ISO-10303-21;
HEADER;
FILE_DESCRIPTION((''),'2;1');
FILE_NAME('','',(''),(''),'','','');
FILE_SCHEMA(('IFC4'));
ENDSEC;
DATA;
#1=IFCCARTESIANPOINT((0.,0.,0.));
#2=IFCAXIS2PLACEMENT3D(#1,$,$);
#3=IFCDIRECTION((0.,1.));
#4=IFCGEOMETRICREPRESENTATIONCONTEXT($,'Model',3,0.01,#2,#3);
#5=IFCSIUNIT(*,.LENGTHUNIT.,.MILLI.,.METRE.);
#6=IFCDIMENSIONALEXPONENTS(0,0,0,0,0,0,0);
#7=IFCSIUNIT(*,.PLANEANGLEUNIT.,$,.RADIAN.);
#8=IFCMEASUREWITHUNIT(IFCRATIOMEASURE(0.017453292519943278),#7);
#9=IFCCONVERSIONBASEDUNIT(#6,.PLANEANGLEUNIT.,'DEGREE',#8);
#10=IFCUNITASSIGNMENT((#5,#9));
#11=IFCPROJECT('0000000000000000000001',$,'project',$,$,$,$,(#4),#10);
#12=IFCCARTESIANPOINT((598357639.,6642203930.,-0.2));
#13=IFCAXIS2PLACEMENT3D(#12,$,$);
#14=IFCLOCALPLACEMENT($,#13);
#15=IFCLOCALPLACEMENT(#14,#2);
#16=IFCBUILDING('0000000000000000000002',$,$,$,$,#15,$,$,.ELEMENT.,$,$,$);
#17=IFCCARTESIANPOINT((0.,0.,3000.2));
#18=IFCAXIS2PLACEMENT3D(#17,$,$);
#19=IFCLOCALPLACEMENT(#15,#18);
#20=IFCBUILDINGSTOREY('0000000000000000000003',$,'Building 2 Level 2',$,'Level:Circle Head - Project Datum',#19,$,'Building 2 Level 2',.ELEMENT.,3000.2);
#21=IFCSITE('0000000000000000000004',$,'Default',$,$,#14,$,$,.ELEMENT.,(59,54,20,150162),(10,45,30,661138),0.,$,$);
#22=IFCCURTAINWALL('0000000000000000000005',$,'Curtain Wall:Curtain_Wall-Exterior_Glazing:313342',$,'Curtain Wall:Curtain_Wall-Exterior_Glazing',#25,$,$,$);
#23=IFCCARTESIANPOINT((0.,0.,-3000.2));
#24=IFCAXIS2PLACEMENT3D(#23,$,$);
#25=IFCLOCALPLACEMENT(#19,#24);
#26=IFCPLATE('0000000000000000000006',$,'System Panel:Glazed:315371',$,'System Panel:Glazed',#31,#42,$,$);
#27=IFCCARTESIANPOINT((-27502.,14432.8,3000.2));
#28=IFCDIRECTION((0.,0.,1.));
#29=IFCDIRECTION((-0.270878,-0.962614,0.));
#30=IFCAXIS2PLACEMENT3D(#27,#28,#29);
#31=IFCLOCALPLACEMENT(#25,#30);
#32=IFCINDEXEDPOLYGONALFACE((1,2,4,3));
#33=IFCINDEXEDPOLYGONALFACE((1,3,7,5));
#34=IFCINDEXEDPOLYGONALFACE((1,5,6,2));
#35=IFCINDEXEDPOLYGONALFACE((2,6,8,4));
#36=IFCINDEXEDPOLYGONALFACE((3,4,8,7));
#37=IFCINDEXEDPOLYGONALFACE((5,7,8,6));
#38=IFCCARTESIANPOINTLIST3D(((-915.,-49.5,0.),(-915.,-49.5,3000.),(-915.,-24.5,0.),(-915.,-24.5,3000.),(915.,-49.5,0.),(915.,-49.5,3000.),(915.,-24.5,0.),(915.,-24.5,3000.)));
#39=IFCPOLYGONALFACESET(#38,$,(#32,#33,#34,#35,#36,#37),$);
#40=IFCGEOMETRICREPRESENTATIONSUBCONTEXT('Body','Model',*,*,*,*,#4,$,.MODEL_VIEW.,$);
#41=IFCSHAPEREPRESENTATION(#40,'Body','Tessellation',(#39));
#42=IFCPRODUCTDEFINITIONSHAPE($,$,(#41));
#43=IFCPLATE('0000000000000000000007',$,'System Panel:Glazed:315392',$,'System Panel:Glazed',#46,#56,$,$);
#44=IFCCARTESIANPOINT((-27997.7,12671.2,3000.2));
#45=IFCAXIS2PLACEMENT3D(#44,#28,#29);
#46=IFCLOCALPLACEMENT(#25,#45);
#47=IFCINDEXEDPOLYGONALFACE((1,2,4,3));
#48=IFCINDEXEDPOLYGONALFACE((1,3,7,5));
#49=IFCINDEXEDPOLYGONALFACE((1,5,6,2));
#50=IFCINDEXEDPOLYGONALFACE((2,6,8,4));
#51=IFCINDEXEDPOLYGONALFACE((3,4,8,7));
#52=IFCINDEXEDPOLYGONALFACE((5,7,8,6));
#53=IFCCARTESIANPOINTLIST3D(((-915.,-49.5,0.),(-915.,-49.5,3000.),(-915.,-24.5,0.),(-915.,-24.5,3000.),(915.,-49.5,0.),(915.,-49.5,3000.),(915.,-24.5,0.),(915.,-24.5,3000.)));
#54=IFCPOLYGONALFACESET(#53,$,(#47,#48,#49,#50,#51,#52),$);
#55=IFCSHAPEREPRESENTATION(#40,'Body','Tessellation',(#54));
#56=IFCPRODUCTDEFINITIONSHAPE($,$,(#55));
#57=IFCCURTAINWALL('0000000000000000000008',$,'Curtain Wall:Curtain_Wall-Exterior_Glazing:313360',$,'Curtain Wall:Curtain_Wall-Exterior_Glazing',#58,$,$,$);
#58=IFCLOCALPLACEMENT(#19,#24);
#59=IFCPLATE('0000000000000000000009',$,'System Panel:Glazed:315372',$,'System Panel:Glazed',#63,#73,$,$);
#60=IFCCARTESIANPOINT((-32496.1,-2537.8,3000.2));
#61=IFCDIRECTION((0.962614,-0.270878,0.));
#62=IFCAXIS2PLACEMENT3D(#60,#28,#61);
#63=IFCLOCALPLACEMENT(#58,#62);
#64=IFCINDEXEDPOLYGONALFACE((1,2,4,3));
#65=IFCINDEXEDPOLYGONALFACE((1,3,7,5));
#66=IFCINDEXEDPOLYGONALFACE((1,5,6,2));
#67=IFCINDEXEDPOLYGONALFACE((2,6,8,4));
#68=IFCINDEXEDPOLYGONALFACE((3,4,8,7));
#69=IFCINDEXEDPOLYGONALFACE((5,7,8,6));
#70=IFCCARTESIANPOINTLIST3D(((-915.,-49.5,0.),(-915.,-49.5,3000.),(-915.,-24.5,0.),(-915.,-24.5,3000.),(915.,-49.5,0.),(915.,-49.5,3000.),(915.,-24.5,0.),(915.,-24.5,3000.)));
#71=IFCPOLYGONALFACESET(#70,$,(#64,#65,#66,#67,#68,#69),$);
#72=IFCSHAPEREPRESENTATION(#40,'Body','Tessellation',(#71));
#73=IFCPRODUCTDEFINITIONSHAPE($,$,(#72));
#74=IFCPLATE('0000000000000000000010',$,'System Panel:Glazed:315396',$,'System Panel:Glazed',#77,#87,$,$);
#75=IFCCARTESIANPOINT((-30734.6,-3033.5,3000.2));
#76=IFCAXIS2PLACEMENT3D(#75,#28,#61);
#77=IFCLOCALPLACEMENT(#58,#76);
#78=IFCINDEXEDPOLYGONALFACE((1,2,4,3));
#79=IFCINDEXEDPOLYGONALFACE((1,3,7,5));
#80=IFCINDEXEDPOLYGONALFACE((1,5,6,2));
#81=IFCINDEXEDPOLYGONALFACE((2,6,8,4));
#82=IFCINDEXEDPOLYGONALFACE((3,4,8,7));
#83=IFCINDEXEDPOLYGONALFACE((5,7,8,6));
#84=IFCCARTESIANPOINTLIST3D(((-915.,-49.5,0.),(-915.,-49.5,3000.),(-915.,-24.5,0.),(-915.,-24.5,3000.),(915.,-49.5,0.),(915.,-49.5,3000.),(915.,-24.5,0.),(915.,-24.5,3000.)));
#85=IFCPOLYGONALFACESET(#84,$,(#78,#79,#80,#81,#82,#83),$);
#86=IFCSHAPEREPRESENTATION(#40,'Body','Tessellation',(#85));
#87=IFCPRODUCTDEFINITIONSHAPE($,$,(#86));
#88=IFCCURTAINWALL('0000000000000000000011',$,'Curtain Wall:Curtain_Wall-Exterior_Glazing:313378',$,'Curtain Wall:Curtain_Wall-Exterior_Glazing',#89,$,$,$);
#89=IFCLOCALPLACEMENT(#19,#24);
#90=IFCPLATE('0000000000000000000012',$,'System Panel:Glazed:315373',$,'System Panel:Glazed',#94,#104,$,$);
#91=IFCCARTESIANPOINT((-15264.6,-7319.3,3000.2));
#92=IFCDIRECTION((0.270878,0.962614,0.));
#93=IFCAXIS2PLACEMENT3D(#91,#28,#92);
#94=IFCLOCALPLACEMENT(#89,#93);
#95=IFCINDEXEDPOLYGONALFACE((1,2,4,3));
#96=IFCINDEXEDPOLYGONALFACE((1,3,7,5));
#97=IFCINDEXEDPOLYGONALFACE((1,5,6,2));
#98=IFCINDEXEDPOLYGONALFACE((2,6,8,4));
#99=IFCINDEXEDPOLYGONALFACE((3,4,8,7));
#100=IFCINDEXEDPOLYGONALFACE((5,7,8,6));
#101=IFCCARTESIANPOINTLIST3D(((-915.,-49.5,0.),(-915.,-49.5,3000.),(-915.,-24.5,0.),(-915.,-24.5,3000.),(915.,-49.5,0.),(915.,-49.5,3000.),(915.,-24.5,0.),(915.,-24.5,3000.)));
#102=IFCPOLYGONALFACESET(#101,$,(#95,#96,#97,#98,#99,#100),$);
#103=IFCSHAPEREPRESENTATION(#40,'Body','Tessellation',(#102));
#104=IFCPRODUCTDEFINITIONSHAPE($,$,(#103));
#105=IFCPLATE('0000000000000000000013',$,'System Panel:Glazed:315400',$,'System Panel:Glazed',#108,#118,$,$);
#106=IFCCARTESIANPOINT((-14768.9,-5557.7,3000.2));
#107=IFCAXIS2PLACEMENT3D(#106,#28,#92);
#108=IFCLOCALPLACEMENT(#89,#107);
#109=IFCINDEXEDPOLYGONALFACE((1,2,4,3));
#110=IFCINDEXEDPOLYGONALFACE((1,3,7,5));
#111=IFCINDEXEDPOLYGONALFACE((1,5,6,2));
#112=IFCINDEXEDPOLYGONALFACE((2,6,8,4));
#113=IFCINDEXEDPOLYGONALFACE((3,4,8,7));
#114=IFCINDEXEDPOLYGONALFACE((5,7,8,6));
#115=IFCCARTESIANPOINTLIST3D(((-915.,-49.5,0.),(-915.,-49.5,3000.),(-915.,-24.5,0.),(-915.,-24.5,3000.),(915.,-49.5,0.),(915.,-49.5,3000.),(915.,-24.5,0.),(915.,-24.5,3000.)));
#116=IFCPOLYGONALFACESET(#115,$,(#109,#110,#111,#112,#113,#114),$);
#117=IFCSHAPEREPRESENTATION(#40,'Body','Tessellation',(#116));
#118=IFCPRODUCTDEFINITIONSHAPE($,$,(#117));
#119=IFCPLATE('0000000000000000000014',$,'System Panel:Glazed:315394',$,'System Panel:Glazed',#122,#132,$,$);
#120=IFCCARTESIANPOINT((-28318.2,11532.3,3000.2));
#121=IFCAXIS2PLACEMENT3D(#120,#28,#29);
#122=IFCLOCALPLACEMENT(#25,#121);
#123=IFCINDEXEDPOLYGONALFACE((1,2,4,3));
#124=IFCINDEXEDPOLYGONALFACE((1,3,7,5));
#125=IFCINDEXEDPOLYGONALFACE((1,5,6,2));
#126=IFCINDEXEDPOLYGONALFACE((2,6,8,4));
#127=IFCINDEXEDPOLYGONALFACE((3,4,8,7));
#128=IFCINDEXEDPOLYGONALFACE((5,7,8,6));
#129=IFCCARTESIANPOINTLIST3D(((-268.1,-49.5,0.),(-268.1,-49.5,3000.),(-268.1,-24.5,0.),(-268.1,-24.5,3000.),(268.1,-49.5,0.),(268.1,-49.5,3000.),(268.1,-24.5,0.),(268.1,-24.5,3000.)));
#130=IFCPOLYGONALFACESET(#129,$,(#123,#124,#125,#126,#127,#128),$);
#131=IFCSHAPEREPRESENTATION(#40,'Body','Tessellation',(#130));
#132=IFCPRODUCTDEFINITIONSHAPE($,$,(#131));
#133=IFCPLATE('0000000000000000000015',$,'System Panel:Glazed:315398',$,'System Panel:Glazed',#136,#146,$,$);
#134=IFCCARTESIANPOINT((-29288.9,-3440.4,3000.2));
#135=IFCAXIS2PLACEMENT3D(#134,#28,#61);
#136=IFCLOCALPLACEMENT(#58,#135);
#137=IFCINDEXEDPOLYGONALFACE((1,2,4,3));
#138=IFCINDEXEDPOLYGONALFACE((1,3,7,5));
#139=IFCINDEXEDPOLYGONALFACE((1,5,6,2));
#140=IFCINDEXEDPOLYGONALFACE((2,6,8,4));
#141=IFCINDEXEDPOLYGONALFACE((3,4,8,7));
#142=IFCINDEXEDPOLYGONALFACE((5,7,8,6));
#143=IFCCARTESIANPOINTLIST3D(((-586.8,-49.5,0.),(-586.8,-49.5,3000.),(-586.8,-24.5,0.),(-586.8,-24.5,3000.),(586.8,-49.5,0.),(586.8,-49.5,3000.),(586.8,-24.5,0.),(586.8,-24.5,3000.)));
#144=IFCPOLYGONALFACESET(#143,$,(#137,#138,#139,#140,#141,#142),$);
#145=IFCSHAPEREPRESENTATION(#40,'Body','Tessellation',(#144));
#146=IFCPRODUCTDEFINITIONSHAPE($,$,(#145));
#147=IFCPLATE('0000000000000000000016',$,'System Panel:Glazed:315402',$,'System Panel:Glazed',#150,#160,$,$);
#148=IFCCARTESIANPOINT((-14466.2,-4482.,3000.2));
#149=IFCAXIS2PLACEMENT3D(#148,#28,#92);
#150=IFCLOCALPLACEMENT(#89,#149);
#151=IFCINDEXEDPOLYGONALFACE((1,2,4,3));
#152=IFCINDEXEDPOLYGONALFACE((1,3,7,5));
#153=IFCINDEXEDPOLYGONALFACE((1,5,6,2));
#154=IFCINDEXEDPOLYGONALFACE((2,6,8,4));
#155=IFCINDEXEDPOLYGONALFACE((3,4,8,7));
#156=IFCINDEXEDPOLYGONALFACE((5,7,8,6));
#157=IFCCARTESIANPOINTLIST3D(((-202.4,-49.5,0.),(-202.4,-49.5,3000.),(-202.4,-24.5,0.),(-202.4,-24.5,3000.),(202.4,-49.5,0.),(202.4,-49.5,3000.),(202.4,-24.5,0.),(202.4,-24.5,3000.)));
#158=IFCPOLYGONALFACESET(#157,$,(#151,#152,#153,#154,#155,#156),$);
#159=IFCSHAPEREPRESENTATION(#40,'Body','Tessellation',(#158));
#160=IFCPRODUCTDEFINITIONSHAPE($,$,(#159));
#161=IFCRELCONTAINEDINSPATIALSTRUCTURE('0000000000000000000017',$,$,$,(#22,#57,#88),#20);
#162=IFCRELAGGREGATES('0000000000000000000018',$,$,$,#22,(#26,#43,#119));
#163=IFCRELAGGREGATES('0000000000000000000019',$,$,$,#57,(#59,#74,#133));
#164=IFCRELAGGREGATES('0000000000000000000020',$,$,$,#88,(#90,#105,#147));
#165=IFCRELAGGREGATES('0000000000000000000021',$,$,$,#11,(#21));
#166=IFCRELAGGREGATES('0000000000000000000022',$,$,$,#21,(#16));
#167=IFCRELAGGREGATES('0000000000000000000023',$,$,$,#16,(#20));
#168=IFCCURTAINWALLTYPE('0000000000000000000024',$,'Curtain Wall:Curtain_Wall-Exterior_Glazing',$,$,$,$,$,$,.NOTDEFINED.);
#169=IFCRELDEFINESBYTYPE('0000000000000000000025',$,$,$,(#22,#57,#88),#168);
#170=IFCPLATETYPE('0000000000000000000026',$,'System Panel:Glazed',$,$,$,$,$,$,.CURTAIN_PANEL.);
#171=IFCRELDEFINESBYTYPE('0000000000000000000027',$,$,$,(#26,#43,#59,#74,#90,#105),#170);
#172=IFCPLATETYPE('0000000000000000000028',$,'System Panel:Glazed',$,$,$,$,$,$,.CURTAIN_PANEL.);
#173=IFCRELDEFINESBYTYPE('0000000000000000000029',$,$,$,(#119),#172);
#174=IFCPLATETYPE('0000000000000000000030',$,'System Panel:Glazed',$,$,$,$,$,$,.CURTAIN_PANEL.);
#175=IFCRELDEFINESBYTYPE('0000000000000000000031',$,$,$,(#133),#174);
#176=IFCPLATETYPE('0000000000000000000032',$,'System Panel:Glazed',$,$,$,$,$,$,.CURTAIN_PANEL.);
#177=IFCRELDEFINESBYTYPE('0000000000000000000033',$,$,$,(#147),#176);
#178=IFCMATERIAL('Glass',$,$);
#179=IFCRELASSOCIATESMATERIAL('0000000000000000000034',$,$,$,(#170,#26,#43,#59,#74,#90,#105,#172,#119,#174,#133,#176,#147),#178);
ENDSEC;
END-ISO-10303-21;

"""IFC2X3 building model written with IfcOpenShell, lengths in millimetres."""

from ifc_helpers import new_model, entity, si_unit, converted_unit, direction, frame, frame_2d, origin, place, context, subcontext, project, spatial, rectangle, extrude, source, transform, mapped, material, type_object, type_shapes, element, aggregate, save


model = new_model("IFC2X3")

# Units and contexts
model_context = context("Model", 3, precision=0.01, world=origin(), true_north=direction((0.0, 1.0)))
body_context = subcontext(model_context, "Body", "Model", "MODEL_VIEW")
ifc_project = project(units=[si_unit("LENGTHUNIT", "METRE", prefix="MILLI"), converted_unit("PLANEANGLEUNIT", "DEGREE", entity("IfcRatioMeasure", 0.017453292519943278), si_unit("PLANEANGLEUNIT", "RADIAN"), dimensions=[0, 0, 0, 0, 0, 0, 0])], contexts=[model_context])

# Site, building, storey
site_placement = place(None, frame((598357639.0, 6642203930.0, -0.2)))
site = spatial("IfcSite", under=ifc_project, at=site_placement, Name="Default", CompositionType="ELEMENT", RefLatitude=(59, 54, 20, 150162), RefLongitude=(10, 45, 30, 661138), RefElevation=0.0)
building_placement = place(site_placement, origin())
building = spatial("IfcBuilding", under=site, at=building_placement, CompositionType="ELEMENT")
storey_placement = place(building_placement, frame((0.0, 0.0, 3000.2)))
storey = spatial("IfcBuildingStorey", under=building, at=storey_placement, Name="Building 2 Level 2", ObjectType="Level:Circle Head - Project Datum", LongName="Building 2 Level 2", CompositionType="ELEMENT", Elevation=3000.2)

# Curtain walls, plates
curtain_wall_type = type_object("IfcCurtainWallType", Name="Curtain Wall:Curtain_Wall-Exterior_Glazing", PredefinedType="NOTDEFINED")
curtain_wall_1_placement = place(storey_placement, frame((0.0, 0.0, -3000.2)))
curtain_wall_1 = element("IfcCurtainWall", 1, at=curtain_wall_1_placement, inside=storey, type_object=curtain_wall_type, Name="Curtain Wall:Curtain_Wall-Exterior_Glazing:313342", ObjectType="Curtain Wall:Curtain_Wall-Exterior_Glazing")
ifc_material_1 = material(Name="Glass")
plate_type_1 = type_object("IfcPlateType", Name="System Panel:Glazed", PredefinedType="CURTAIN_PANEL", material=ifc_material_1)
shared_shape_1 = source(origin(), body_context, "Body", "SweptSolid", [
    extrude(rectangle(XDim=25.0, YDim=1830.0, at=frame_2d((0.0, 0.0), x_axis=(1.0, 0.0))), frame((0.0, -37.0, 0.0), z_axis=(0.0, 0.0, 1.0), x_axis=(0.0, 1.0, 0.0)), (0.0, 0.0, 1.0), 3000.0),
])
type_shapes(plate_type_1, [shared_shape_1])
plate_1_placement = place(curtain_wall_1_placement, frame((-27502.0, 14432.8, 3000.2), z_axis=(0.0, 0.0, 1.0), x_axis=(-0.270878, -0.962614, 0.0)))
plate_1 = element("IfcPlate", 2, at=plate_1_placement, type_object=plate_type_1, material=ifc_material_1, Name="System Panel:Glazed:315371", ObjectType="System Panel:Glazed", context=body_context, shape_type="MappedRepresentation", body=[
    mapped(shared_shape_1, transform((0.0, 0.0, 0.0), scale=1.0)),
])
plate_2_placement = place(curtain_wall_1_placement, frame((-27997.7, 12671.2, 3000.2), z_axis=(0.0, 0.0, 1.0), x_axis=(-0.270878, -0.962614, 0.0)))
plate_2 = element("IfcPlate", 3, at=plate_2_placement, type_object=plate_type_1, material=ifc_material_1, Name="System Panel:Glazed:315392", ObjectType="System Panel:Glazed", context=body_context, shape_type="MappedRepresentation", body=[
    mapped(shared_shape_1, transform((0.0, 0.0, 0.0), scale=1.0)),
])
curtain_wall_2_placement = place(storey_placement, frame((0.0, 0.0, -3000.2)))
curtain_wall_2 = element("IfcCurtainWall", 4, at=curtain_wall_2_placement, inside=storey, type_object=curtain_wall_type, Name="Curtain Wall:Curtain_Wall-Exterior_Glazing:313360", ObjectType="Curtain Wall:Curtain_Wall-Exterior_Glazing")
plate_3_placement = place(curtain_wall_2_placement, frame((-32496.1, -2537.8, 3000.2), z_axis=(0.0, 0.0, 1.0), x_axis=(0.962614, -0.270878, 0.0)))
plate_3 = element("IfcPlate", 5, at=plate_3_placement, type_object=plate_type_1, material=ifc_material_1, Name="System Panel:Glazed:315372", ObjectType="System Panel:Glazed", context=body_context, shape_type="MappedRepresentation", body=[
    mapped(shared_shape_1, transform((0.0, 0.0, 0.0), scale=1.0)),
])
plate_4_placement = place(curtain_wall_2_placement, frame((-30734.6, -3033.5, 3000.2), z_axis=(0.0, 0.0, 1.0), x_axis=(0.962614, -0.270878, 0.0)))
plate_4 = element("IfcPlate", 6, at=plate_4_placement, type_object=plate_type_1, material=ifc_material_1, Name="System Panel:Glazed:315396", ObjectType="System Panel:Glazed", context=body_context, shape_type="MappedRepresentation", body=[
    mapped(shared_shape_1, transform((0.0, 0.0, 0.0), scale=1.0)),
])
curtain_wall_3_placement = place(storey_placement, frame((0.0, 0.0, -3000.2)))
curtain_wall_3 = element("IfcCurtainWall", 7, at=curtain_wall_3_placement, inside=storey, type_object=curtain_wall_type, Name="Curtain Wall:Curtain_Wall-Exterior_Glazing:313378", ObjectType="Curtain Wall:Curtain_Wall-Exterior_Glazing")
plate_5_placement = place(curtain_wall_3_placement, frame((-15264.6, -7319.3, 3000.2), z_axis=(0.0, 0.0, 1.0), x_axis=(0.270878, 0.962614, 0.0)))
plate_5 = element("IfcPlate", 8, at=plate_5_placement, type_object=plate_type_1, material=ifc_material_1, Name="System Panel:Glazed:315373", ObjectType="System Panel:Glazed", context=body_context, shape_type="MappedRepresentation", body=[
    mapped(shared_shape_1, transform((0.0, 0.0, 0.0), scale=1.0)),
])
plate_6_placement = place(curtain_wall_3_placement, frame((-14768.9, -5557.7, 3000.2), z_axis=(0.0, 0.0, 1.0), x_axis=(0.270878, 0.962614, 0.0)))
plate_6 = element("IfcPlate", 9, at=plate_6_placement, type_object=plate_type_1, material=ifc_material_1, Name="System Panel:Glazed:315400", ObjectType="System Panel:Glazed", context=body_context, shape_type="MappedRepresentation", body=[
    mapped(shared_shape_1, transform((0.0, 0.0, 0.0), scale=1.0)),
])

# Plates
plate_type_2 = type_object("IfcPlateType", Name="System Panel:Glazed", PredefinedType="CURTAIN_PANEL", material=ifc_material_1)
shared_shape_2 = source(origin(), body_context, "Body", "SweptSolid", [
    extrude(rectangle(XDim=25.0, YDim=536.2, at=frame_2d((0.0, 0.0), x_axis=(1.0, 0.0))), frame((0.0, -37.0, 0.0), z_axis=(0.0, 0.0, 1.0), x_axis=(0.0, 1.0, 0.0)), (0.0, 0.0, 1.0), 3000.0),
])
type_shapes(plate_type_2, [shared_shape_2])
plate_7_placement = place(curtain_wall_1_placement, frame((-28318.2, 11532.3, 3000.2), z_axis=(0.0, 0.0, 1.0), x_axis=(-0.270878, -0.962614, 0.0)))
plate_7 = element("IfcPlate", 10, at=plate_7_placement, type_object=plate_type_2, material=ifc_material_1, Name="System Panel:Glazed:315394", ObjectType="System Panel:Glazed", context=body_context, shape_type="MappedRepresentation", body=[
    mapped(shared_shape_2, transform((0.0, 0.0, 0.0), scale=1.0)),
])
aggregate(curtain_wall_1, [plate_1, plate_2, plate_7])
plate_type_3 = type_object("IfcPlateType", Name="System Panel:Glazed", PredefinedType="CURTAIN_PANEL", material=ifc_material_1)
shared_shape_3 = source(origin(), body_context, "Body", "SweptSolid", [
    extrude(rectangle(XDim=25.0, YDim=1173.6, at=frame_2d((0.0, 0.0), x_axis=(1.0, 0.0))), frame((0.0, -37.0, 0.0), z_axis=(0.0, 0.0, 1.0), x_axis=(0.0, 1.0, 0.0)), (0.0, 0.0, 1.0), 3000.0),
])
type_shapes(plate_type_3, [shared_shape_3])
plate_8_placement = place(curtain_wall_2_placement, frame((-29288.9, -3440.4, 3000.2), z_axis=(0.0, 0.0, 1.0), x_axis=(0.962614, -0.270878, 0.0)))
plate_8 = element("IfcPlate", 11, at=plate_8_placement, type_object=plate_type_3, material=ifc_material_1, Name="System Panel:Glazed:315398", ObjectType="System Panel:Glazed", context=body_context, shape_type="MappedRepresentation", body=[
    mapped(shared_shape_3, transform((0.0, 0.0, 0.0), scale=1.0)),
])
aggregate(curtain_wall_2, [plate_3, plate_4, plate_8])
plate_type_4 = type_object("IfcPlateType", Name="System Panel:Glazed", PredefinedType="CURTAIN_PANEL", material=ifc_material_1)
shared_shape_4 = source(origin(), body_context, "Body", "SweptSolid", [
    extrude(rectangle(XDim=25.0, YDim=404.8, at=frame_2d((0.0, 0.0), x_axis=(1.0, 0.0))), frame((0.0, -37.0, 0.0), z_axis=(0.0, 0.0, 1.0), x_axis=(0.0, 1.0, 0.0)), (0.0, 0.0, 1.0), 3000.0),
])
type_shapes(plate_type_4, [shared_shape_4])
plate_9_placement = place(curtain_wall_3_placement, frame((-14466.2, -4482.0, 3000.2), z_axis=(0.0, 0.0, 1.0), x_axis=(0.270878, 0.962614, 0.0)))
plate_9 = element("IfcPlate", 12, at=plate_9_placement, type_object=plate_type_4, material=ifc_material_1, Name="System Panel:Glazed:315402", ObjectType="System Panel:Glazed", context=body_context, shape_type="MappedRepresentation", body=[
    mapped(shared_shape_4, transform((0.0, 0.0, 0.0), scale=1.0)),
])
aggregate(curtain_wall_3, [plate_5, plate_6, plate_9])

save(model, "model.ifc")
